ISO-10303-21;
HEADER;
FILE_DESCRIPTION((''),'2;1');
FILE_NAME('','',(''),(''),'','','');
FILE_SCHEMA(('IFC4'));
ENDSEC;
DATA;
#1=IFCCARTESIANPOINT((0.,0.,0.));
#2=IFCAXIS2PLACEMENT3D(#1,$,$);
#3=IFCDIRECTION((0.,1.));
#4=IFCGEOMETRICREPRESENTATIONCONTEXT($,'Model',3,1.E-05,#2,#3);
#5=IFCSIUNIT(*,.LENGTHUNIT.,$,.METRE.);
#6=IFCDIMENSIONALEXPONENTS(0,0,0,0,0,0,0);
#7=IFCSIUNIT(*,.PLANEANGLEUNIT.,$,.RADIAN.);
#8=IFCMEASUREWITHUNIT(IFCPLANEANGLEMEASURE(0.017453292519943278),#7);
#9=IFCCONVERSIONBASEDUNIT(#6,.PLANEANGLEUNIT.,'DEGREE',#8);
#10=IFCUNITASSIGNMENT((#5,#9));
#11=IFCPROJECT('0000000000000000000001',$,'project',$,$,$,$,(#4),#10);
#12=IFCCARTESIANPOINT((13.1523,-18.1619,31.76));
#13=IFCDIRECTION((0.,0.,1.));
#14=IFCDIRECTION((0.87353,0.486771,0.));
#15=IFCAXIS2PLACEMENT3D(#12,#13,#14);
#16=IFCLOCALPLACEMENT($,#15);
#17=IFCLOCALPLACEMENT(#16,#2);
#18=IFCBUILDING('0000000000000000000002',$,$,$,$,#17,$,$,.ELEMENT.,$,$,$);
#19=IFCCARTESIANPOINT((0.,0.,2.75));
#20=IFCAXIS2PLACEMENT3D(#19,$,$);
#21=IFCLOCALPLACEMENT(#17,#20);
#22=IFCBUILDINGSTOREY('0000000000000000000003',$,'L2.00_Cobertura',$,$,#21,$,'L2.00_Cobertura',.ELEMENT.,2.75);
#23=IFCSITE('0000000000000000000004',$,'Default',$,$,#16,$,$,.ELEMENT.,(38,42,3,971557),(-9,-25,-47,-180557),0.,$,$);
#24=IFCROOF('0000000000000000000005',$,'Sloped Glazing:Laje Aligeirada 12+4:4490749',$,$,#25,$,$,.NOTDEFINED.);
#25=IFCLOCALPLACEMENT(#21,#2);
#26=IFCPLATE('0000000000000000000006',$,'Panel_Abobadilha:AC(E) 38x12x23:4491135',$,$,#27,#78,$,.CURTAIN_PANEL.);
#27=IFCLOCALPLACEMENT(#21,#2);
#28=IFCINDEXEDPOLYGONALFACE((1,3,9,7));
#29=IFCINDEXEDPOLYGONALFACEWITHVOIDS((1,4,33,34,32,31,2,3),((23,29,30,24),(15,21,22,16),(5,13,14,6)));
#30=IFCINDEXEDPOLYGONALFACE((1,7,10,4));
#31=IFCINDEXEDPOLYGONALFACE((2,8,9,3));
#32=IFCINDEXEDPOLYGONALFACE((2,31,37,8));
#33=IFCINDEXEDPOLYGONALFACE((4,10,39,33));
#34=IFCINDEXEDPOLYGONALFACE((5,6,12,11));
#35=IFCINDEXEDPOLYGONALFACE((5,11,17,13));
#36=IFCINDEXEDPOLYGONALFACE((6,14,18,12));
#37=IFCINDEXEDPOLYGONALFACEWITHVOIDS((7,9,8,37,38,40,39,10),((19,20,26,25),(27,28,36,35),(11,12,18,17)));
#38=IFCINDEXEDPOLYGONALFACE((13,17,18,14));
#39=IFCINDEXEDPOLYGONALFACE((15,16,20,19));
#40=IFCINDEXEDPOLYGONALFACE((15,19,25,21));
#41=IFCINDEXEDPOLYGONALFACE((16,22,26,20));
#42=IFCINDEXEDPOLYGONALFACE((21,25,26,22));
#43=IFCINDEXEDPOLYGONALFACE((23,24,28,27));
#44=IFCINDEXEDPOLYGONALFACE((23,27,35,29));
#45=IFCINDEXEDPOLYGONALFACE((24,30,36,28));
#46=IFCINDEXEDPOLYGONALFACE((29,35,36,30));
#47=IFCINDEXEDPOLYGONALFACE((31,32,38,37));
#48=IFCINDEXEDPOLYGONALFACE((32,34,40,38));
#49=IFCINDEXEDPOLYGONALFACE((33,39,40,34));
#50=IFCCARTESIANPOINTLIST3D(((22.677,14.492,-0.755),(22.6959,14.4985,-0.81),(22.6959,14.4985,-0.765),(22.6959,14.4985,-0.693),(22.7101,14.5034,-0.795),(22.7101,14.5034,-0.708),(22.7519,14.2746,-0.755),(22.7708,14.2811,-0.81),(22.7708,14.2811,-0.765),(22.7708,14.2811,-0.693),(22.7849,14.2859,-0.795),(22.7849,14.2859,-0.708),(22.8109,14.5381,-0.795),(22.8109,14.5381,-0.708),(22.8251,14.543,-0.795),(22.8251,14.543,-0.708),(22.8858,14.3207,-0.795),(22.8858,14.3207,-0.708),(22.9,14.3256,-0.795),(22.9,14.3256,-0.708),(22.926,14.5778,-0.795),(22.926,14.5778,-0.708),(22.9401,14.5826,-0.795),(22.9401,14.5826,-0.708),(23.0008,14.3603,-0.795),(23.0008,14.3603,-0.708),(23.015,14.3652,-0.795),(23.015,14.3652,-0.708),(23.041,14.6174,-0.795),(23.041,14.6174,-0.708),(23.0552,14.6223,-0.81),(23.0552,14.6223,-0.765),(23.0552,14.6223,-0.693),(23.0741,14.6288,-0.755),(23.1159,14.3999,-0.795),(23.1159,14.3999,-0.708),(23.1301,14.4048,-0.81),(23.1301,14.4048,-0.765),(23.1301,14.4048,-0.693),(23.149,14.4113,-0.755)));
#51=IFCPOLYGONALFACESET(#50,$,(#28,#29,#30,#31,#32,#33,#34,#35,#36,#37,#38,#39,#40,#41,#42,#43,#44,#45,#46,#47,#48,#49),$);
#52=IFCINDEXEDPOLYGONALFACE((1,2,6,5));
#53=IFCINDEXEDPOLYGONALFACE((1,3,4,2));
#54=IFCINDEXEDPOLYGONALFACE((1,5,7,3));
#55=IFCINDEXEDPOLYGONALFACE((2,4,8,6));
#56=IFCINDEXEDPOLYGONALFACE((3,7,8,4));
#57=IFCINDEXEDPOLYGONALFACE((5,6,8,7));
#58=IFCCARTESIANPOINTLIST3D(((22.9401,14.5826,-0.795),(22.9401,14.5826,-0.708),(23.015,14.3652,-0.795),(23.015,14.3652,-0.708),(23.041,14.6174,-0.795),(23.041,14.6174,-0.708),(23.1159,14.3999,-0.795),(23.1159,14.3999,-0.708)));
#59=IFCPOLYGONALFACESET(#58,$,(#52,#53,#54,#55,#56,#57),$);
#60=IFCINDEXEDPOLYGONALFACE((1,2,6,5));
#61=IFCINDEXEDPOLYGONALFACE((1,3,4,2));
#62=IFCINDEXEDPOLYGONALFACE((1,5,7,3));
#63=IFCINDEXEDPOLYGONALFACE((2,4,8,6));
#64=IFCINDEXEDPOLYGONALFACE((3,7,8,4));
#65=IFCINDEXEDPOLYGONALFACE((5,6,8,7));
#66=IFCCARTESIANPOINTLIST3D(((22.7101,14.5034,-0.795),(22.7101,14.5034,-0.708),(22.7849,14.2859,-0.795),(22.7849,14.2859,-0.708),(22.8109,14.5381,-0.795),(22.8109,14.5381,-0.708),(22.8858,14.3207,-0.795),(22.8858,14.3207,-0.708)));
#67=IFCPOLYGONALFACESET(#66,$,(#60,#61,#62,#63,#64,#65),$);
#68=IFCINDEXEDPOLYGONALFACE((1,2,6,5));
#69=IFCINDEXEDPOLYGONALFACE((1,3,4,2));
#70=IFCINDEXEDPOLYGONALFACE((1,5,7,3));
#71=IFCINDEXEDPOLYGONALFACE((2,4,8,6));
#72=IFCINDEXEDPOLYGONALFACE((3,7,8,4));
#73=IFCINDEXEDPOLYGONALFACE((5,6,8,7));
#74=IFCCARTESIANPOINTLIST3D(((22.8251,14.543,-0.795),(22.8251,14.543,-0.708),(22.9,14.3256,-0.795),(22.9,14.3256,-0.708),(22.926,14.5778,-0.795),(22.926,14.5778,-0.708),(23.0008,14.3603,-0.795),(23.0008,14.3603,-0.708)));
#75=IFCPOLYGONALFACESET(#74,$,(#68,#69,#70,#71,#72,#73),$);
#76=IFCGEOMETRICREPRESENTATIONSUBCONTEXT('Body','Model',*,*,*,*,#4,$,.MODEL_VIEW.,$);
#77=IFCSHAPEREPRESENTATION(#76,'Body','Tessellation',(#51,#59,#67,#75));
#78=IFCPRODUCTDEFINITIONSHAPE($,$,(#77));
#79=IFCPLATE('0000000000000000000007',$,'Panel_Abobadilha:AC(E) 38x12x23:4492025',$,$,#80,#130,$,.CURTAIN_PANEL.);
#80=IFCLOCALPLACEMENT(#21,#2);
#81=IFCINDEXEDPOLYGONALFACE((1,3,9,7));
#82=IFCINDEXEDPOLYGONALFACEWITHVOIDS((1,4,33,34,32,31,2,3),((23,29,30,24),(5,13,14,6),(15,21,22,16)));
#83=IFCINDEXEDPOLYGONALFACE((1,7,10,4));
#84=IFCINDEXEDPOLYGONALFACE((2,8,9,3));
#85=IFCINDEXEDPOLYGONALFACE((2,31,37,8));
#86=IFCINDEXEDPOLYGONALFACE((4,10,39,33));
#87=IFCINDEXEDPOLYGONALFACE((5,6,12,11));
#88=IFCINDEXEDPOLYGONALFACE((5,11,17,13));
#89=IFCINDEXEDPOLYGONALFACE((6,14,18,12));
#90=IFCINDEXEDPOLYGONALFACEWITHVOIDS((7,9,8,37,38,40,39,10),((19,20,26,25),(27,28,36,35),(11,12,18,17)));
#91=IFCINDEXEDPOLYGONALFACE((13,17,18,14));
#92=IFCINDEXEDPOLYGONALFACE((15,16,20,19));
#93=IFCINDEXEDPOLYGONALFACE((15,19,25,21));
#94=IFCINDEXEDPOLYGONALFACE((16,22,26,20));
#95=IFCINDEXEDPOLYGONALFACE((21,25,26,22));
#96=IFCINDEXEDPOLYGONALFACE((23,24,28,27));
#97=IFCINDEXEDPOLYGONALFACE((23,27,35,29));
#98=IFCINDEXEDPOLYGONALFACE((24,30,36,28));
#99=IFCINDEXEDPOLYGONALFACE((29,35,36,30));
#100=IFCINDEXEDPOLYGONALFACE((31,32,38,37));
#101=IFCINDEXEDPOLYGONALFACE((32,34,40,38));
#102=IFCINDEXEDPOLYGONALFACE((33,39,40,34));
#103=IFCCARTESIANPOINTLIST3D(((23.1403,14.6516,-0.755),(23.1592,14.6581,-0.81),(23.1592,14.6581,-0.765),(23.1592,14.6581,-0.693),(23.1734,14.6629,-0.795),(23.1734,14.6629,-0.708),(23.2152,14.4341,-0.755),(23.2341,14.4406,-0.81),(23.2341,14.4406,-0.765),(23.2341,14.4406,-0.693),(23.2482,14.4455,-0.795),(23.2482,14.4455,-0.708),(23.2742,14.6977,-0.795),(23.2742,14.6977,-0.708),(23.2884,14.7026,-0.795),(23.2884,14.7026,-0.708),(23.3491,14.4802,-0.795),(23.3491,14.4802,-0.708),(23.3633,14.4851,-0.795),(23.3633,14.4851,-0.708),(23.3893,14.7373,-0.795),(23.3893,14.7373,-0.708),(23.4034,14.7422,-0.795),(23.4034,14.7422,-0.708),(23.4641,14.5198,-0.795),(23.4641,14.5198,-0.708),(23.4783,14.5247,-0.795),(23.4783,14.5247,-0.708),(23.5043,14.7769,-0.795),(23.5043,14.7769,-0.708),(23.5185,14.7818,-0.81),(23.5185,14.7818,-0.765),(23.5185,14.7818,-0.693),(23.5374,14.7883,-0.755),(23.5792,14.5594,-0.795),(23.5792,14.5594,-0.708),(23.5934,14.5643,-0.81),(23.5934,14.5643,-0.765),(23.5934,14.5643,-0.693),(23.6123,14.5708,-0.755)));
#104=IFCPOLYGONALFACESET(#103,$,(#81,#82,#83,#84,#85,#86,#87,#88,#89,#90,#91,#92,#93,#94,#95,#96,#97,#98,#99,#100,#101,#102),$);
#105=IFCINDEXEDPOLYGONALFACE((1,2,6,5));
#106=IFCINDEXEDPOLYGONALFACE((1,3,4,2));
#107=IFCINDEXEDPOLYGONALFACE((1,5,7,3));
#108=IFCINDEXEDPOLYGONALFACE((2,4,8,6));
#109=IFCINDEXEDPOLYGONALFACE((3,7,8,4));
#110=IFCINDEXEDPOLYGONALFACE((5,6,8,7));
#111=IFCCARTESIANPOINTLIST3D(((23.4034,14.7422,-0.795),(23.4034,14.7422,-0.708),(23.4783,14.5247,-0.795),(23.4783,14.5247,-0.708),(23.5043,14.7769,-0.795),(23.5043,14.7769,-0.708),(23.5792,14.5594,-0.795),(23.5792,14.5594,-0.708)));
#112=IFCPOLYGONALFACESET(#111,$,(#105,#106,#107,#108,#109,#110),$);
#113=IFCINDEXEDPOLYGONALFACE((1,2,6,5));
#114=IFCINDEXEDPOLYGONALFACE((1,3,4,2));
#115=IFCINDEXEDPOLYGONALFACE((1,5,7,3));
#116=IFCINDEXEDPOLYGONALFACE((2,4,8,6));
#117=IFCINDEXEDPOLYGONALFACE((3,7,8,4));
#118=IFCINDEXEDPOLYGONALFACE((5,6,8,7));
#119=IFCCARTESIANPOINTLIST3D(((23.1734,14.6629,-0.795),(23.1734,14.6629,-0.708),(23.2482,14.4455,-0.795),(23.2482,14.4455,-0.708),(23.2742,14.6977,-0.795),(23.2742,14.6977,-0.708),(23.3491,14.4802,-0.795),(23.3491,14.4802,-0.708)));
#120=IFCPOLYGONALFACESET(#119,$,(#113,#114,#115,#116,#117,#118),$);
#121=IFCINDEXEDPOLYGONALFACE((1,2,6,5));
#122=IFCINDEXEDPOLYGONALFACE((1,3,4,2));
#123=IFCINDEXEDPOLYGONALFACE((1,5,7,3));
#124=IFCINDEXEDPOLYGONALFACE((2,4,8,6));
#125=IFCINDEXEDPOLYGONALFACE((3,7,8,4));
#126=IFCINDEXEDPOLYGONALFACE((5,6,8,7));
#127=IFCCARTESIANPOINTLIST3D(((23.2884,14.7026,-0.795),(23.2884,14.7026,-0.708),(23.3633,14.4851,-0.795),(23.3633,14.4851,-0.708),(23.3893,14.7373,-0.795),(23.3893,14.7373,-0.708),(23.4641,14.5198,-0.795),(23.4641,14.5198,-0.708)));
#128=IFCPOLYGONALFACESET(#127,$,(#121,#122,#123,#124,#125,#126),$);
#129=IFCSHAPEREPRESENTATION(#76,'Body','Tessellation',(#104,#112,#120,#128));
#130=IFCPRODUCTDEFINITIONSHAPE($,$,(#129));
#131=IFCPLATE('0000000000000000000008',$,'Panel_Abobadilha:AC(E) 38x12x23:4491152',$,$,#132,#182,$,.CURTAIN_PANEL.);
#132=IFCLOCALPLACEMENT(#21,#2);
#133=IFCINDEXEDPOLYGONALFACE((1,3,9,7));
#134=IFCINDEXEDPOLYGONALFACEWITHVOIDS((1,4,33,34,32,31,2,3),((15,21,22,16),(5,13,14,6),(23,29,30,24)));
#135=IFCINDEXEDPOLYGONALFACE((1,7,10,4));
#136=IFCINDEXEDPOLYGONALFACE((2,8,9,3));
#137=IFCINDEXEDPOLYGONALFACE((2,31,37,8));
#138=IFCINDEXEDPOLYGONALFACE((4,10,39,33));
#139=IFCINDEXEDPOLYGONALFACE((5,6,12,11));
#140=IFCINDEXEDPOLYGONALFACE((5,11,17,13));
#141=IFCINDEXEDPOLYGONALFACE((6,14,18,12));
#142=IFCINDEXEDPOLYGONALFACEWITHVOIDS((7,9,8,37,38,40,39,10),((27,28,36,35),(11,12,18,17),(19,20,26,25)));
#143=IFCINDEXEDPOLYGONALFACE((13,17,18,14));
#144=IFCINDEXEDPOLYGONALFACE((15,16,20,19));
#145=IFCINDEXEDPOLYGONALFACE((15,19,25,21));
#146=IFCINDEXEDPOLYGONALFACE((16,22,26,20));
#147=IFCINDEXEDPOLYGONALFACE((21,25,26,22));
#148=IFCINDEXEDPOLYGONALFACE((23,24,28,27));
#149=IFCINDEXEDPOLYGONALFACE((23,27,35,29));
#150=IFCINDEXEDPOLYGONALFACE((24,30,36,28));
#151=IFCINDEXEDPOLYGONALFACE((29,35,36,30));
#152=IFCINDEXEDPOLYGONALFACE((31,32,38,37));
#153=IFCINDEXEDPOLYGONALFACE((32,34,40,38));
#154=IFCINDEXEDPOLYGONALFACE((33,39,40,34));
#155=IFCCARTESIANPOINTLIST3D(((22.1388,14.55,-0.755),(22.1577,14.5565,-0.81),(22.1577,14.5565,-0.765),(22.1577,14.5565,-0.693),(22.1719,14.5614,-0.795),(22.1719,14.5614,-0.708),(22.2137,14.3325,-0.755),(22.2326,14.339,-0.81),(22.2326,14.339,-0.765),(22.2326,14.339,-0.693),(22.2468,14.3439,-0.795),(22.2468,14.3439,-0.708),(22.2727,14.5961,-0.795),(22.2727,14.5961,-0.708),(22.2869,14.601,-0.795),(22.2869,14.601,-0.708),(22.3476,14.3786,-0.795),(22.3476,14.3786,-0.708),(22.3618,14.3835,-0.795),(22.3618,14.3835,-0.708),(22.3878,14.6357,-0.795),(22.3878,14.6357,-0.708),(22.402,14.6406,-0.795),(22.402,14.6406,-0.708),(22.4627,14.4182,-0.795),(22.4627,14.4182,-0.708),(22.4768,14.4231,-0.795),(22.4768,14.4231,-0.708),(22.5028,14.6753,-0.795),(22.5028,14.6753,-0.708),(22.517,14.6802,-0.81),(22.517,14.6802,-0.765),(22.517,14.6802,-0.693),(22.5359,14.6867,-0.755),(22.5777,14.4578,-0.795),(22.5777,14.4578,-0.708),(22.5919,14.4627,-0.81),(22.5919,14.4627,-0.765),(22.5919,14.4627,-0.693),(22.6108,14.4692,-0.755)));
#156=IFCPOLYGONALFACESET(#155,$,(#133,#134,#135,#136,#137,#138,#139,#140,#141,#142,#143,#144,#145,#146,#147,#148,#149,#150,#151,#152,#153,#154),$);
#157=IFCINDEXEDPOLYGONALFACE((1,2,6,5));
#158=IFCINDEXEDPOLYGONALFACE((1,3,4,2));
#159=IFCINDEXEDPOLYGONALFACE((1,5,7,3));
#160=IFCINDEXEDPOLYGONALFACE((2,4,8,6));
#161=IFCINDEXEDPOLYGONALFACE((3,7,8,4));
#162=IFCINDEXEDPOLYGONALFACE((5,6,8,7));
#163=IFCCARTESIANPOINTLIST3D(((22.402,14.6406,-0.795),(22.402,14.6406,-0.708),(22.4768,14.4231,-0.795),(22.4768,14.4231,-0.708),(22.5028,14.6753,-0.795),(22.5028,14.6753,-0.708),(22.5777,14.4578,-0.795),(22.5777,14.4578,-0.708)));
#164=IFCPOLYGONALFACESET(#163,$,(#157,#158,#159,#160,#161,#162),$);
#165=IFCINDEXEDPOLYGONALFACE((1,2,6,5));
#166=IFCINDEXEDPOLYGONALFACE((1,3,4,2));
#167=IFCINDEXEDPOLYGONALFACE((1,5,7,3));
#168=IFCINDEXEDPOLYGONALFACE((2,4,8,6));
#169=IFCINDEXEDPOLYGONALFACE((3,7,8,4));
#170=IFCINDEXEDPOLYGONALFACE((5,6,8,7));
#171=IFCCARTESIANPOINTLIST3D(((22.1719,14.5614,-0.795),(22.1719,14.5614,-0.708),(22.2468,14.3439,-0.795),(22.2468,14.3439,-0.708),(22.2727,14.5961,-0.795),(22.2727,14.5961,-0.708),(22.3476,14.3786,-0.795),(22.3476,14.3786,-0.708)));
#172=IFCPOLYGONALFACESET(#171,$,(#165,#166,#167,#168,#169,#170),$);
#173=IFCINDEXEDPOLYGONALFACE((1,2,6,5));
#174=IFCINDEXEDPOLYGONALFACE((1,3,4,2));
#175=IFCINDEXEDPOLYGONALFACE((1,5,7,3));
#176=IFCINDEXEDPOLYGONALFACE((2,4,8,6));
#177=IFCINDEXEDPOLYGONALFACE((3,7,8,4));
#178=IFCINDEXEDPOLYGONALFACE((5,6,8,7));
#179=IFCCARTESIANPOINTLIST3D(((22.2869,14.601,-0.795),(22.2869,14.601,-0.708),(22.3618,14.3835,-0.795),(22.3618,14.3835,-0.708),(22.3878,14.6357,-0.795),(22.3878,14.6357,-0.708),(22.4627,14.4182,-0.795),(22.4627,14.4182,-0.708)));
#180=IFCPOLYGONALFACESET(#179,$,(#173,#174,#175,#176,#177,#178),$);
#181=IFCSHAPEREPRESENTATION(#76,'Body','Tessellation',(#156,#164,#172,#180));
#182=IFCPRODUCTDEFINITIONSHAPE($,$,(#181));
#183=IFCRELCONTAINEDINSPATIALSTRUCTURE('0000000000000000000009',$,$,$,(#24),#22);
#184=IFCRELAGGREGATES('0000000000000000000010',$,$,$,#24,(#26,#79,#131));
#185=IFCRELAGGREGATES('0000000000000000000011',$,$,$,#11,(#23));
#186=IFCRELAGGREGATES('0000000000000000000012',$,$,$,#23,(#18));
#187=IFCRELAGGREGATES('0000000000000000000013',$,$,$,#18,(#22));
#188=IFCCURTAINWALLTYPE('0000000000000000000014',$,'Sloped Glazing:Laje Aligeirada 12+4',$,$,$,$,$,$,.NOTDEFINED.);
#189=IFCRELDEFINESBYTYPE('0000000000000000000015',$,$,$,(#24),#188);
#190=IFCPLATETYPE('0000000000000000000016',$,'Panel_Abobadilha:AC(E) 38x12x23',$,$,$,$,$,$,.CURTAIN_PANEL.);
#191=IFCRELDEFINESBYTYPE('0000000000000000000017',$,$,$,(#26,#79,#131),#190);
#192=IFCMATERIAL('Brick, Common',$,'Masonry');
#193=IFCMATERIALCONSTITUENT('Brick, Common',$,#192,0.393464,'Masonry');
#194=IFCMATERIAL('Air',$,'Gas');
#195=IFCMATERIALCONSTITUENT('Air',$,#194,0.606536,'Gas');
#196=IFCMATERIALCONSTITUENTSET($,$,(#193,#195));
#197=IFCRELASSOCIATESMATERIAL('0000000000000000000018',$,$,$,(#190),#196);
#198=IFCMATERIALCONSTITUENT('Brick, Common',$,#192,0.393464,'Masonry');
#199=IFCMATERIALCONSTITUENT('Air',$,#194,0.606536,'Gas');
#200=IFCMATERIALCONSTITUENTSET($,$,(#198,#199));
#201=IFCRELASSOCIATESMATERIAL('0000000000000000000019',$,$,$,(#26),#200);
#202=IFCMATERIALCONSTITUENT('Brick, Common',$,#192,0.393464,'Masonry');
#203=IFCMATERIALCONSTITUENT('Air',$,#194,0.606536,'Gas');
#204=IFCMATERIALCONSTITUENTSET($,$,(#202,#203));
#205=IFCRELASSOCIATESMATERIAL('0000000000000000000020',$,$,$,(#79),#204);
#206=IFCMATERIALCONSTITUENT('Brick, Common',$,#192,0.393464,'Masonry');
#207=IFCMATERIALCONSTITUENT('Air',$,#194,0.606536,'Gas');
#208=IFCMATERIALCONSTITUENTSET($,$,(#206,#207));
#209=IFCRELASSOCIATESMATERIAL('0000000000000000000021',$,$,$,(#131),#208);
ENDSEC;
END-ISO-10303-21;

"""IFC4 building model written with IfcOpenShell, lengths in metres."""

from ifc_helpers import new_model, entity, si_unit, converted_unit, direction, frame, origin, place, context, subcontext, project, spatial, indexed_curve, outline, extrude, source, transform, mapped, material, constituent, constituent_set, type_object, type_shapes, element, aggregate, save


model = new_model("IFC4")

# Units and contexts
model_context = context("Model", 3, precision=1e-05, world=origin(), true_north=direction((0.0, 1.0)))
body_context = subcontext(model_context, "Body", "Model", "MODEL_VIEW")
ifc_project = project(units=[si_unit("LENGTHUNIT", "METRE"), converted_unit("PLANEANGLEUNIT", "DEGREE", entity("IfcPlaneAngleMeasure", 0.017453292519943278), si_unit("PLANEANGLEUNIT", "RADIAN"), dimensions=[0, 0, 0, 0, 0, 0, 0])], contexts=[model_context])

# Site, building, storey
site_placement = place(None, frame((13.1523, -18.1619, 31.76), z_axis=(0.0, 0.0, 1.0), x_axis=(0.87353, 0.486771, 0.0)))
site = spatial("IfcSite", under=ifc_project, at=site_placement, Name="Default", CompositionType="ELEMENT", RefLatitude=(38, 42, 3, 971557), RefLongitude=(-9, -25, -47, -180557), RefElevation=0.0)
building_placement = place(site_placement, origin())
building = spatial("IfcBuilding", under=site, at=building_placement, CompositionType="ELEMENT")
storey_placement = place(building_placement, frame((0.0, 0.0, 2.75)))
storey = spatial("IfcBuildingStorey", under=building, at=storey_placement, Name="L2.00_Cobertura", LongName="L2.00_Cobertura", CompositionType="ELEMENT", Elevation=2.75)

# Roof, plates
curtain_wall_type = type_object("IfcCurtainWallType", Name="Sloped Glazing:Laje Aligeirada 12+4", PredefinedType="NOTDEFINED")
roof_placement = place(storey_placement, frame((0.0, 0.0, -2.75)))
roof = element("IfcRoof", 1, at=roof_placement, inside=storey, type_object=curtain_wall_type, Name="Sloped Glazing:Laje Aligeirada 12+4:4490749", PredefinedType="NOTDEFINED")
ifc_material_1 = material(Name="Brick, Common", Category="Masonry")
ifc_material_2 = material(Name="Air", Category="Gas")
ifc_constituent_1 = constituent(ifc_material_1, Name="Brick, Common", Category="Masonry", fraction=0.393464)
ifc_constituent_2 = constituent(ifc_material_2, Name="Air", Category="Gas", fraction=0.606536)
ifc_constituent_set_1 = constituent_set(constituents=[ifc_constituent_1, ifc_constituent_2])
plate_type = type_object("IfcPlateType", Name="Panel_Abobadilha:AC(E) 38x12x23", PredefinedType="CURTAIN_PANEL", material=ifc_constituent_set_1)
shared_shape_1 = source(origin(), body_context, "Body", "SweptSolid", [
    extrude(outline(indexed_curve([(-0.19, -0.0543), (0.19, -0.0543), (0.19, -0.0093), (0.21, 0.0007), (0.19, 0.0628), (-0.19, 0.0628), (-0.21, 0.0007), (-0.19, -0.0093), (-0.19, -0.0543)], self_intersect=False), holes=[indexed_curve([(-0.0683, 0.0477), (-0.0683, -0.0393), (-0.175, -0.0393), (-0.175, 0.0477), (-0.0683, 0.0477)], self_intersect=False), indexed_curve([(0.0533, 0.0477), (0.0533, -0.0393), (-0.0533, -0.0393), (-0.0533, 0.0477), (0.0533, 0.0477)], self_intersect=False), indexed_curve([(0.175, 0.0477), (0.175, -0.0393), (0.0683, -0.0393), (0.0683, 0.0477), (0.175, 0.0477)], self_intersect=False)]), frame((0.0, 0.0543, 0.0)), (0.0, 0.0, 1.0), 0.23),
    extrude(outline(indexed_curve([(-0.0533, -0.0435), (0.0533, -0.0435), (0.0533, 0.0435), (-0.0533, 0.0435), (-0.0533, -0.0435)], self_intersect=False)), frame((0.1217, 0.0585, 0.0), z_axis=(0.0, 0.0, 1.0), x_axis=(-1.0, 0.0, 0.0)), (0.0, 0.0, 1.0), 0.23),
    extrude(outline(indexed_curve([(-0.0533, -0.0435), (0.0533, -0.0435), (0.0533, 0.0435), (-0.0533, 0.0435), (-0.0533, -0.0435)], self_intersect=False)), frame((-0.1217, 0.0585, 0.0), z_axis=(0.0, 0.0, 1.0), x_axis=(-1.0, 0.0, 0.0)), (0.0, 0.0, 1.0), 0.23),
    extrude(outline(indexed_curve([(-0.0533, -0.0435), (0.0533, -0.0435), (0.0533, 0.0435), (-0.0533, 0.0435), (-0.0533, -0.0435)], self_intersect=False)), frame((0.0, 0.0585, 0.0), z_axis=(0.0, 0.0, 1.0), x_axis=(-1.0, 0.0, 0.0)), (0.0, 0.0, 1.0), 0.23),
])
type_shapes(plate_type, [shared_shape_1])
ifc_constituent_3 = constituent(ifc_material_1, Name="Brick, Common", Category="Masonry", fraction=0.393464)
ifc_constituent_4 = constituent(ifc_material_2, Name="Air", Category="Gas", fraction=0.606536)
ifc_constituent_set_2 = constituent_set(constituents=[ifc_constituent_3, ifc_constituent_4])
plate_1_placement = place(roof_placement, frame((22.8755, 14.5604, 1.94), z_axis=(0.325568, -0.945519, 0.0), x_axis=(0.945519, 0.325568, 0.0)))
plate_1 = element("IfcPlate", 2, at=plate_1_placement, type_object=plate_type, material=ifc_constituent_set_2, Name="Panel_Abobadilha:AC(E) 38x12x23:4491135", PredefinedType="CURTAIN_PANEL", context=body_context, shape_type="MappedRepresentation", body=[
    mapped(shared_shape_1, transform((0.0, 0.0, 0.0), scale=1.0)),
])
ifc_constituent_5 = constituent(ifc_material_1, Name="Brick, Common", Category="Masonry", fraction=0.393464)
ifc_constituent_6 = constituent(ifc_material_2, Name="Air", Category="Gas", fraction=0.606536)
ifc_constituent_set_3 = constituent_set(constituents=[ifc_constituent_5, ifc_constituent_6])
plate_2_placement = place(roof_placement, frame((23.3388, 14.7199, 1.94), z_axis=(0.325568, -0.945519, 0.0), x_axis=(0.945519, 0.325568, 0.0)))
plate_2 = element("IfcPlate", 3, at=plate_2_placement, type_object=plate_type, material=ifc_constituent_set_3, Name="Panel_Abobadilha:AC(E) 38x12x23:4492025", PredefinedType="CURTAIN_PANEL", context=body_context, shape_type="MappedRepresentation", body=[
    mapped(shared_shape_1, transform((0.0, 0.0, 0.0), scale=1.0)),
])
ifc_constituent_7 = constituent(ifc_material_1, Name="Brick, Common", Category="Masonry", fraction=0.393464)
ifc_constituent_8 = constituent(ifc_material_2, Name="Air", Category="Gas", fraction=0.606536)
ifc_constituent_set_4 = constituent_set(constituents=[ifc_constituent_7, ifc_constituent_8])
plate_3_placement = place(roof_placement, frame((22.3373, 14.6183, 1.94), z_axis=(0.325568, -0.945519, 0.0), x_axis=(0.945519, 0.325568, 0.0)))
plate_3 = element("IfcPlate", 4, at=plate_3_placement, type_object=plate_type, material=ifc_constituent_set_4, Name="Panel_Abobadilha:AC(E) 38x12x23:4491152", PredefinedType="CURTAIN_PANEL", context=body_context, shape_type="MappedRepresentation", body=[
    mapped(shared_shape_1, transform((0.0, 0.0, 0.0), scale=1.0)),
])
aggregate(roof, [plate_1, plate_2, plate_3])

save(model, "model.ifc")
